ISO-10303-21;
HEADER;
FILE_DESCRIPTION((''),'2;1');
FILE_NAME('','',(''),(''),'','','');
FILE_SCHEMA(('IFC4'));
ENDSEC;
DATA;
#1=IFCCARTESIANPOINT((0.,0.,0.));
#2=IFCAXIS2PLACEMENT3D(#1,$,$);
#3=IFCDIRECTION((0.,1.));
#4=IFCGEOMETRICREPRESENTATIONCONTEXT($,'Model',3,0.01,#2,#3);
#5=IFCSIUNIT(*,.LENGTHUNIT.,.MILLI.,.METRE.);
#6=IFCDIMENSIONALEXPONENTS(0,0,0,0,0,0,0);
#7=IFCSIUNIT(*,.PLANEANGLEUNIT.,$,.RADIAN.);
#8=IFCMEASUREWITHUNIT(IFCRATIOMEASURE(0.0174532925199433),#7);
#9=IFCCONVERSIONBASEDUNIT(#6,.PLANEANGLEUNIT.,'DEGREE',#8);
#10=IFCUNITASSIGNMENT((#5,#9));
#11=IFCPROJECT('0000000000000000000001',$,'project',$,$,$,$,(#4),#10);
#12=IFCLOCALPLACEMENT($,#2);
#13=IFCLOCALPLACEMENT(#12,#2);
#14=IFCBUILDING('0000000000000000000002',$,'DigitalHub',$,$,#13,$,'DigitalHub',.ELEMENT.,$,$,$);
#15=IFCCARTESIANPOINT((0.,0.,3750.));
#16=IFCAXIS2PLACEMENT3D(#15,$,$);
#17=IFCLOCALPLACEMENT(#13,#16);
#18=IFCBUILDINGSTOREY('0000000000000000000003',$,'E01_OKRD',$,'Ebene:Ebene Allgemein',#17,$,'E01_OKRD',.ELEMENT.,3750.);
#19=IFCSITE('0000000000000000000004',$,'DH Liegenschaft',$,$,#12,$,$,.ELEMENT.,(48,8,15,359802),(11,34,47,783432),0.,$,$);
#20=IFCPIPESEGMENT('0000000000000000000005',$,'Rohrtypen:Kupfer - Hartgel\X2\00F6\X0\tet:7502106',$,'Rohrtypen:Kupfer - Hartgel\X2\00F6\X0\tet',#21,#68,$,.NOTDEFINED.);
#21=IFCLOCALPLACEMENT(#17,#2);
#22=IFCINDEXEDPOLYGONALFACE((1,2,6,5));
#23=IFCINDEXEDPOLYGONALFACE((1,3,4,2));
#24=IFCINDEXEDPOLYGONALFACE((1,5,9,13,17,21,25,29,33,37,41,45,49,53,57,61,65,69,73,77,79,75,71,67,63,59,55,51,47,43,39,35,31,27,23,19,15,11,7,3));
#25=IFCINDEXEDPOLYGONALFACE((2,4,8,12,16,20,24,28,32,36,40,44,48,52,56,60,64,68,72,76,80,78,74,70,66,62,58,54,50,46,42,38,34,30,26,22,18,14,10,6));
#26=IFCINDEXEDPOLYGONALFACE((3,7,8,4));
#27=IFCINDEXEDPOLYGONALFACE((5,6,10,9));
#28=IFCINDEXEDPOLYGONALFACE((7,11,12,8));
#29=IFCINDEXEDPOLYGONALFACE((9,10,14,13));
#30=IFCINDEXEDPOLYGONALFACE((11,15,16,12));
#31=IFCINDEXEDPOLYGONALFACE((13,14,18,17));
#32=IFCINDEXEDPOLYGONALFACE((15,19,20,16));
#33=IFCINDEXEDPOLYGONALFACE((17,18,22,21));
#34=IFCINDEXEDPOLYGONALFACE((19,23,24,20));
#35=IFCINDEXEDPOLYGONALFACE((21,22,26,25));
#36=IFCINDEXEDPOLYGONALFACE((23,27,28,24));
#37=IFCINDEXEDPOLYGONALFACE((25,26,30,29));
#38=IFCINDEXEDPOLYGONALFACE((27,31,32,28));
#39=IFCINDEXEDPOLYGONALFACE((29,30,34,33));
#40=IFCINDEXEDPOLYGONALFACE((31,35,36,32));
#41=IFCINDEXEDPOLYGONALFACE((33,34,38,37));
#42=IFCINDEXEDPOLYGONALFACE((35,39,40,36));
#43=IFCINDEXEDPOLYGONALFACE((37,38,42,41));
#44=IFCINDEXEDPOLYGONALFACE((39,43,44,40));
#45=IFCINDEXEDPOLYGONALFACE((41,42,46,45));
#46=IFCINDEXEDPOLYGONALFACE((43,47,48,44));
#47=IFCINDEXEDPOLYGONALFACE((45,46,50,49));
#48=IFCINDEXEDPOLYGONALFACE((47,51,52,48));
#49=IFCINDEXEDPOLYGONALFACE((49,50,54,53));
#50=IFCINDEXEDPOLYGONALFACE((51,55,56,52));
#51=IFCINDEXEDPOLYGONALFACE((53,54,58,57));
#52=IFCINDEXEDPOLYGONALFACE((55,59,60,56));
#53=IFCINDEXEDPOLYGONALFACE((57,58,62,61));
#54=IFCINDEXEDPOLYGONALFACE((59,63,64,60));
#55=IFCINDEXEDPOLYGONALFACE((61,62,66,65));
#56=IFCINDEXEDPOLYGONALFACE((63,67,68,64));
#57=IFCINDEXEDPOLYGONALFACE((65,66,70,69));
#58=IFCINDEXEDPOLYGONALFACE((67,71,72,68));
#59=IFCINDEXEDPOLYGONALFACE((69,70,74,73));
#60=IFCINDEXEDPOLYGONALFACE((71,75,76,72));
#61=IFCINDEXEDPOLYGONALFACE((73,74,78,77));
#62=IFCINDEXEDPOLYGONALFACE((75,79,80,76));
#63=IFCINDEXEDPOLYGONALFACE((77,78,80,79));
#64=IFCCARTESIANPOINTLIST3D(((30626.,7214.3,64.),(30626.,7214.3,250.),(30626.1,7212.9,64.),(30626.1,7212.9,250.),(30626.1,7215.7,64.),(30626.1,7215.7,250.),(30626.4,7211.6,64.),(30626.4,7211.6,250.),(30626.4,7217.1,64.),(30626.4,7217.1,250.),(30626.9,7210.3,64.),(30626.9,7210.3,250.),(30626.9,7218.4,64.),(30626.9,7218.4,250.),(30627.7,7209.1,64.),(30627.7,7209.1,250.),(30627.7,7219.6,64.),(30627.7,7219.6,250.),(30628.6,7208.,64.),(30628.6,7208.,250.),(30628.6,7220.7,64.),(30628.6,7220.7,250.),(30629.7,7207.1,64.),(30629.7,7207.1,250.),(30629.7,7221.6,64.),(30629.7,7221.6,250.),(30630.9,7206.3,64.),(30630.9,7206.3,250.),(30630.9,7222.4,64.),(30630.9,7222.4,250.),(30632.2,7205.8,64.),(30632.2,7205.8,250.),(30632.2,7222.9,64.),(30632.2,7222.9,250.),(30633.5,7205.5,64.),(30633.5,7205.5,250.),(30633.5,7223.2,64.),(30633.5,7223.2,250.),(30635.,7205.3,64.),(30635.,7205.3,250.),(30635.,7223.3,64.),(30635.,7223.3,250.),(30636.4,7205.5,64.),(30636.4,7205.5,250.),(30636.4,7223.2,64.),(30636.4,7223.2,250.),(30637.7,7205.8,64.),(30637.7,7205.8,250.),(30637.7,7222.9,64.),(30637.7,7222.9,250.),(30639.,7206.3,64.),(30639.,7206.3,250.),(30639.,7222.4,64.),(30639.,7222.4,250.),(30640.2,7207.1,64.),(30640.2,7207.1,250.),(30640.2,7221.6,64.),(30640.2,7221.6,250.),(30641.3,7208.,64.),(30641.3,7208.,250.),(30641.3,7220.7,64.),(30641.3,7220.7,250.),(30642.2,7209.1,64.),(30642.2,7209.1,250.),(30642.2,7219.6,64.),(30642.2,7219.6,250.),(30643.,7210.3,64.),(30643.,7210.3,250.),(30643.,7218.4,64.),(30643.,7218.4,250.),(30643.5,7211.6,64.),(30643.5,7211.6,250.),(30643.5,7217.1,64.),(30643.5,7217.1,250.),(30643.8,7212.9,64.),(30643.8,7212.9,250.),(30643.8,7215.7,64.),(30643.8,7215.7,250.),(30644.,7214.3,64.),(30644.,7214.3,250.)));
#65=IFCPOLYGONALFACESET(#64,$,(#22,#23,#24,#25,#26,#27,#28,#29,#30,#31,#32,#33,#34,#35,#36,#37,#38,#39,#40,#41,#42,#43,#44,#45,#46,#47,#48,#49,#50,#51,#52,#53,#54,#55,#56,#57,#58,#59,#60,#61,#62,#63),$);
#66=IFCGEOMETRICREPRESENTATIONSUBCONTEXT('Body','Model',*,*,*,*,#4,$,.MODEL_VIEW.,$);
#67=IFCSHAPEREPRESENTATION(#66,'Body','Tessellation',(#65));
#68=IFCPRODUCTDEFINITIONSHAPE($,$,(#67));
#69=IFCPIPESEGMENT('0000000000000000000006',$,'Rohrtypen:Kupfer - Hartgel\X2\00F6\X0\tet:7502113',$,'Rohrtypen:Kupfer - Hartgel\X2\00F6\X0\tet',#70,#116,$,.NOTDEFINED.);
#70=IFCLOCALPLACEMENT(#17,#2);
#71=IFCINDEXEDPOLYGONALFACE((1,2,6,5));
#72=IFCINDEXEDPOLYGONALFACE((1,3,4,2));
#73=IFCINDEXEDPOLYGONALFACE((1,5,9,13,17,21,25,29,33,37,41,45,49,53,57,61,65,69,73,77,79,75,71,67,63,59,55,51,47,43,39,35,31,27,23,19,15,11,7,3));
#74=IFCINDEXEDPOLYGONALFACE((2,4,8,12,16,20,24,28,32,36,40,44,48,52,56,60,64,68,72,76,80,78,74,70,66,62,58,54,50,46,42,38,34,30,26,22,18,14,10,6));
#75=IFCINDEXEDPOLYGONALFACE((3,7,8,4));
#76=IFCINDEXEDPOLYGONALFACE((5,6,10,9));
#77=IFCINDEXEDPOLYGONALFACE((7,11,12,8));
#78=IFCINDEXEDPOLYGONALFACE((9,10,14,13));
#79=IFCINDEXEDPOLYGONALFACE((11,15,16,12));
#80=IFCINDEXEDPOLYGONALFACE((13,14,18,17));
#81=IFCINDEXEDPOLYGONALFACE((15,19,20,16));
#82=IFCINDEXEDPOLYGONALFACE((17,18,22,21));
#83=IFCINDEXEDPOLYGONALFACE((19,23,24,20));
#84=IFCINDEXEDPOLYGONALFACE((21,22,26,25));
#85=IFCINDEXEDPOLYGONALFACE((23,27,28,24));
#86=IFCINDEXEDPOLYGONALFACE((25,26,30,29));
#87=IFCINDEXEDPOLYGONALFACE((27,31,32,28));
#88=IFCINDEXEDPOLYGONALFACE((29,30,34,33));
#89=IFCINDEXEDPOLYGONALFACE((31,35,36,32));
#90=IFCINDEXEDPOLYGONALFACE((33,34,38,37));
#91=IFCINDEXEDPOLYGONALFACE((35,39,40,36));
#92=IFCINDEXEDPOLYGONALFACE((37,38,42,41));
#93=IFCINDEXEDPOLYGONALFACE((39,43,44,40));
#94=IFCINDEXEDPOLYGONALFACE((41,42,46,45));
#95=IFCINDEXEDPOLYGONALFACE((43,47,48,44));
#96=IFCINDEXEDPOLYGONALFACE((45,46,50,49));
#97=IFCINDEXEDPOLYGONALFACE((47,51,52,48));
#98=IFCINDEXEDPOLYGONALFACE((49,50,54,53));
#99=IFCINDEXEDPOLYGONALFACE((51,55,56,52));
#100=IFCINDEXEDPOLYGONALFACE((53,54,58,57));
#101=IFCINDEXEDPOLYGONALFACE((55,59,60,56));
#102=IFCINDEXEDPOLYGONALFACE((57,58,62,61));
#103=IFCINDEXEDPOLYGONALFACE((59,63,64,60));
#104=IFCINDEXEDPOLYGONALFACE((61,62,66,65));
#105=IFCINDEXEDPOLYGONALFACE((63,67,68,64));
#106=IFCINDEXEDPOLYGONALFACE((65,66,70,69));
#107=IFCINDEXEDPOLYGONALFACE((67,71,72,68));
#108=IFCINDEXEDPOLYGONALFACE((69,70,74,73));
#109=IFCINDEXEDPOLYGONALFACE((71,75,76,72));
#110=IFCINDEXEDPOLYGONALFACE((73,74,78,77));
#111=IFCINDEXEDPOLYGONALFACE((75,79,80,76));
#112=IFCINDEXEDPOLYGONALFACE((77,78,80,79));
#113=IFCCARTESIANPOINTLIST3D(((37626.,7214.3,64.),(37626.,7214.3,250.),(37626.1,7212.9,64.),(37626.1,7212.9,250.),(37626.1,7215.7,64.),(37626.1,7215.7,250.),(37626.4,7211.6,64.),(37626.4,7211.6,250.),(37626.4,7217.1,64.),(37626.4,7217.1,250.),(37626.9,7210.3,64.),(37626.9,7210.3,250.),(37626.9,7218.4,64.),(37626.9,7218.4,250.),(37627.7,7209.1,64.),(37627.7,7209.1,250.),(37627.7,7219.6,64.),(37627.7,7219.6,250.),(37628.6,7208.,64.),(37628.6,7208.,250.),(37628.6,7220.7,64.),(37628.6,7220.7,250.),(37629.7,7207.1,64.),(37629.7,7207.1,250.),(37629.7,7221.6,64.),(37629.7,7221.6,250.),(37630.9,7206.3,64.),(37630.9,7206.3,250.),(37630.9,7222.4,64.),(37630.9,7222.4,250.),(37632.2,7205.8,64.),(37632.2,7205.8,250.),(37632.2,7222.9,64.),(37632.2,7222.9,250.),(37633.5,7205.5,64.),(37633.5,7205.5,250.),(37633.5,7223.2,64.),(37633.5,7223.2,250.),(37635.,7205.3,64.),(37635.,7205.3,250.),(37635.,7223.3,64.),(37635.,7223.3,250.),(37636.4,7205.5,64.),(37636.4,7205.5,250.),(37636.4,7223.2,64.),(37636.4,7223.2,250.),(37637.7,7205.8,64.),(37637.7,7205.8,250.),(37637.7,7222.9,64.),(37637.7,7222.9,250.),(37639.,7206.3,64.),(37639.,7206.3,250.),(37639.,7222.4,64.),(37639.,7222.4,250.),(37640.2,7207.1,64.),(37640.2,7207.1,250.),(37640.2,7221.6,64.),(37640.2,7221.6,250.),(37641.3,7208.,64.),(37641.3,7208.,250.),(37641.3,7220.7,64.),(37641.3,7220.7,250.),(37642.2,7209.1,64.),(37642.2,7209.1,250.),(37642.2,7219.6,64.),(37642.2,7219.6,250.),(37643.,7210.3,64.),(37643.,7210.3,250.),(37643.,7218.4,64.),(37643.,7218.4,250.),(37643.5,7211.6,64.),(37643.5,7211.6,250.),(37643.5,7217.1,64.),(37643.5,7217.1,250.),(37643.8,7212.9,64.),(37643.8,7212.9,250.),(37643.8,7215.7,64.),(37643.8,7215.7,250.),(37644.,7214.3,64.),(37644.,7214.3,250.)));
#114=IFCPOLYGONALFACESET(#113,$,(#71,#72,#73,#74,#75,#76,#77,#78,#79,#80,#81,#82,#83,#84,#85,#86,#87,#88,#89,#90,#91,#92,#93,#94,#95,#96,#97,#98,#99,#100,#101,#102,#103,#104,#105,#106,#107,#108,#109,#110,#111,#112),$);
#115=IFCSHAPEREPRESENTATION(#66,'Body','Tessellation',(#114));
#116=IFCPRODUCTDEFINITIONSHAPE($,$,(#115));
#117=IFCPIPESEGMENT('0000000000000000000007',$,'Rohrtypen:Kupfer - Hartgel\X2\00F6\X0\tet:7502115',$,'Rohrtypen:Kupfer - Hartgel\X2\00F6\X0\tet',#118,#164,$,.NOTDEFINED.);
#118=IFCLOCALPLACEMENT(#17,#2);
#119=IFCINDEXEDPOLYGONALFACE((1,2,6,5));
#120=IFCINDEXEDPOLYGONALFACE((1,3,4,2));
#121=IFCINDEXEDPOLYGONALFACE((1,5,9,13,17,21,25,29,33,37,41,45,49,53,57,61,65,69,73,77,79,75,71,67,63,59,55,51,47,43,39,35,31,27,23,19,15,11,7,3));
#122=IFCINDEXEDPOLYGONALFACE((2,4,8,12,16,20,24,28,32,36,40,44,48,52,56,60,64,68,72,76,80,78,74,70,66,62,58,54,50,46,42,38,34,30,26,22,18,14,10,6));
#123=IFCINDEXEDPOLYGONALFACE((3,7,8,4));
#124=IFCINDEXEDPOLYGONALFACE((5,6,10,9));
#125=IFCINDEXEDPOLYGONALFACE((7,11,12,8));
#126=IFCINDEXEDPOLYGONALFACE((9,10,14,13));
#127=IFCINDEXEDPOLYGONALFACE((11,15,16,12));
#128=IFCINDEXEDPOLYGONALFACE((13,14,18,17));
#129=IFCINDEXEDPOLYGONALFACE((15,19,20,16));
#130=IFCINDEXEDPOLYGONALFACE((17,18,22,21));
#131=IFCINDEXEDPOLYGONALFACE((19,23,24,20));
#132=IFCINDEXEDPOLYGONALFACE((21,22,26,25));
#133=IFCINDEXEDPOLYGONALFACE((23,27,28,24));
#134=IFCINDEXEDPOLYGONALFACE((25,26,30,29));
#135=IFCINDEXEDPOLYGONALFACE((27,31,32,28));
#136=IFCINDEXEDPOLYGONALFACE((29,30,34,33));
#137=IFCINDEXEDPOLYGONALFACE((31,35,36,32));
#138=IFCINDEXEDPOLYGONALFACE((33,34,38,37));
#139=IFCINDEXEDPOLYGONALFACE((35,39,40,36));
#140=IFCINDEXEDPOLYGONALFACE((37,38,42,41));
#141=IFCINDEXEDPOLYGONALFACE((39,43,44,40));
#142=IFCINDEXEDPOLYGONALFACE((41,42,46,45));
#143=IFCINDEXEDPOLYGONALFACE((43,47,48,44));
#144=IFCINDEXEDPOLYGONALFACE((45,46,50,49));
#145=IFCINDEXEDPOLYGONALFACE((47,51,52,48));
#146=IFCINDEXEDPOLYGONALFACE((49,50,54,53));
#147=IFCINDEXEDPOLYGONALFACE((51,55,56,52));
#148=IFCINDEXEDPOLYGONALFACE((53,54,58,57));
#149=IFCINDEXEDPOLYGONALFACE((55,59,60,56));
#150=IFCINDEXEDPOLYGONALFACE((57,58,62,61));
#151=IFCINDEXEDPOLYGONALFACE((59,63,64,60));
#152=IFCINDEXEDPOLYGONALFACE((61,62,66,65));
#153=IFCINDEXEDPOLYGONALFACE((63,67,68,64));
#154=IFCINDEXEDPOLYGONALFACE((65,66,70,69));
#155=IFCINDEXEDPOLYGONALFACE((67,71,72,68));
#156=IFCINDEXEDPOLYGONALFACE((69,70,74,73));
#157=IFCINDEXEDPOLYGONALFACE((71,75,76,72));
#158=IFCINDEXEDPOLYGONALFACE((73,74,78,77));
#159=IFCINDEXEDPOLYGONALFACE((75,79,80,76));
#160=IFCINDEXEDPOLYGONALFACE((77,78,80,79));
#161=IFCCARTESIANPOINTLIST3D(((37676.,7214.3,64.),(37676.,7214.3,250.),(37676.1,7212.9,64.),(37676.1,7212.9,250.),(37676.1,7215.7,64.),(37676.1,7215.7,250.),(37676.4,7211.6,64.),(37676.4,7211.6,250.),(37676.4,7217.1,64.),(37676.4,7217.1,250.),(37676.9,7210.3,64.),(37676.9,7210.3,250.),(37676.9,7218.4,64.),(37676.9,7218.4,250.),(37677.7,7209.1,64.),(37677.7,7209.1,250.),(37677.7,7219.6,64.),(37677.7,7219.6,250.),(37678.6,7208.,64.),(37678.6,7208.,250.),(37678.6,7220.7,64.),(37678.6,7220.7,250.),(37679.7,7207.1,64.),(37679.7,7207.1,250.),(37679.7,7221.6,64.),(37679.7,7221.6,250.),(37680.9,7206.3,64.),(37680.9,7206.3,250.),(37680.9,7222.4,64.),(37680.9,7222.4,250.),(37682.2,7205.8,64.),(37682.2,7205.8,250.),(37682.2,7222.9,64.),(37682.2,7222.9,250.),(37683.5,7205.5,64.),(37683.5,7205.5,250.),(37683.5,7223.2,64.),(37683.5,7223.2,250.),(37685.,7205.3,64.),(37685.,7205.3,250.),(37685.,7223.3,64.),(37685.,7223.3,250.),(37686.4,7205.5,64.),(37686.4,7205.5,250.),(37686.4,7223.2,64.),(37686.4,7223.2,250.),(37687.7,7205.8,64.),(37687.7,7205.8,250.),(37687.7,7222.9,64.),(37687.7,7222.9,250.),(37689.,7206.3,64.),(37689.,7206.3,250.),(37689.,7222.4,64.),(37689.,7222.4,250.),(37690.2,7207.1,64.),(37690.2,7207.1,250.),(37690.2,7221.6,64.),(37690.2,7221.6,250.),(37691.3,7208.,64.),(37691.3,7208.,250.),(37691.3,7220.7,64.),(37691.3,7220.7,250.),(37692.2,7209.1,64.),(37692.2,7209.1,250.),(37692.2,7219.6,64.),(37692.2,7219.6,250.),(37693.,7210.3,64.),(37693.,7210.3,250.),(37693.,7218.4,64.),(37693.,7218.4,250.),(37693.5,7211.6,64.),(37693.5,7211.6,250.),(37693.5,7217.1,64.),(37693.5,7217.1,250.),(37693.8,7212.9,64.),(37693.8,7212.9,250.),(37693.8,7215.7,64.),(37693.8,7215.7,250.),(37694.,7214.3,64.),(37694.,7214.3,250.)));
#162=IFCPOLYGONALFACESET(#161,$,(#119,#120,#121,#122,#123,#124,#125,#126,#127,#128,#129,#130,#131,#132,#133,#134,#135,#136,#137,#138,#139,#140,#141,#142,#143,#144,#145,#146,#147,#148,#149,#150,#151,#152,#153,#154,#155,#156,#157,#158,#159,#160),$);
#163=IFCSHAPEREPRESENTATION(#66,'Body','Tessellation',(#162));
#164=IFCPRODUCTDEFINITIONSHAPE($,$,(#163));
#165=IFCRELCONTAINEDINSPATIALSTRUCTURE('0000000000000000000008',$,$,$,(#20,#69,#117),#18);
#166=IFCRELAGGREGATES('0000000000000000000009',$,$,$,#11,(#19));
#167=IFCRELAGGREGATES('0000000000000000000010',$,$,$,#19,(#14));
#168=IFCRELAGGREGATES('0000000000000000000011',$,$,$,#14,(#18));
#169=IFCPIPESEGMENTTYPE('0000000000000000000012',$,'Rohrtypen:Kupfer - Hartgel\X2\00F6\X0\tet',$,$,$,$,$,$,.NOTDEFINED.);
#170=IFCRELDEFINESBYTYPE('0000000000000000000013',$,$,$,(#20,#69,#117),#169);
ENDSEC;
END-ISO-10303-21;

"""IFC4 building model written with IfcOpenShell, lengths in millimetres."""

from ifc_helpers import new_model, entity, si_unit, converted_unit, direction, frame, origin, place, context, subcontext, project, spatial, indexed_curve, outline, extrude, type_object, element, save


model = new_model("IFC4")

# Units and contexts
model_context = context("Model", 3, precision=0.01, world=origin(), true_north=direction((0.0, 1.0)))
body_context = subcontext(model_context, "Body", "Model", "MODEL_VIEW")
ifc_project = project(units=[si_unit("LENGTHUNIT", "METRE", prefix="MILLI"), converted_unit("PLANEANGLEUNIT", "DEGREE", entity("IfcRatioMeasure", 0.0174532925199433), si_unit("PLANEANGLEUNIT", "RADIAN"), dimensions=[0, 0, 0, 0, 0, 0, 0])], contexts=[model_context])

# Site, building, storey
site_placement = place(None, origin())
site = spatial("IfcSite", under=ifc_project, at=site_placement, Name="DH Liegenschaft", CompositionType="ELEMENT", RefLatitude=(48, 8, 15, 359802), RefLongitude=(11, 34, 47, 783432), RefElevation=0.0)
building_placement = place(site_placement, origin())
building = spatial("IfcBuilding", under=site, at=building_placement, Name="DigitalHub", LongName="DigitalHub", CompositionType="ELEMENT")
storey_placement = place(building_placement, frame((0.0, 0.0, 3750.0)))
storey = spatial("IfcBuildingStorey", under=building, at=storey_placement, Name="E01_OKRD", ObjectType="Ebene:Ebene Allgemein", LongName="E01_OKRD", CompositionType="ELEMENT", Elevation=3750.0)

# Pipe segments
pipe_segment_type = type_object("IfcPipeSegmentType", Name="Rohrtypen:Kupfer - Hartgelötet", PredefinedType="NOTDEFINED")
pipe_segment_1_placement = place(storey_placement, frame((30624.4, 7203.7, 64.0)))
element("IfcPipeSegment", 1, at=pipe_segment_1_placement, inside=storey, type_object=pipe_segment_type, Name="Rohrtypen:Kupfer - Hartgelötet:7502106", ObjectType="Rohrtypen:Kupfer - Hartgelötet", PredefinedType="NOTDEFINED", context=body_context, shape_type="SweptSolid", body=[
    extrude(outline(indexed_curve([(9.0, 0.0), (8.9, 1.4), (8.6, 2.8), (8.0, 4.1), (7.3, 5.3), (6.4, 6.4), (5.3, 7.3), (4.1, 8.0), (2.8, 8.6), (1.4, 8.9), (0.0, 9.0), (-1.4, 8.9), (-2.8, 8.6), (-4.1, 8.0), (-5.3, 7.3), (-6.4, 6.4), (-7.3, 5.3), (-8.0, 4.1), (-8.6, 2.8), (-8.9, 1.4), (-9.0, 0.0), (-8.9, -1.4), (-8.6, -2.8), (-8.0, -4.1), (-7.3, -5.3), (-6.4, -6.4), (-5.3, -7.3), (-4.1, -8.0), (-2.8, -8.6), (-1.4, -8.9), (0.0, -9.0), (1.4, -8.9), (2.8, -8.6), (4.1, -8.0), (5.3, -7.3), (6.4, -6.4), (7.3, -5.3), (8.0, -4.1), (8.6, -2.8), (8.9, -1.4), (9.0, 0.0)], self_intersect=False)), frame((10.6, 10.6, 0.0)), (0.0, 0.0, 1.0), 186.0),
])
pipe_segment_2_placement = place(storey_placement, frame((37624.4, 7203.7, 64.0)))
element("IfcPipeSegment", 2, at=pipe_segment_2_placement, inside=storey, type_object=pipe_segment_type, Name="Rohrtypen:Kupfer - Hartgelötet:7502113", ObjectType="Rohrtypen:Kupfer - Hartgelötet", PredefinedType="NOTDEFINED", context=body_context, shape_type="SweptSolid", body=[
    extrude(outline(indexed_curve([(9.0, 0.0), (8.9, 1.4), (8.6, 2.8), (8.0, 4.1), (7.3, 5.3), (6.4, 6.4), (5.3, 7.3), (4.1, 8.0), (2.8, 8.6), (1.4, 8.9), (0.0, 9.0), (-1.4, 8.9), (-2.8, 8.6), (-4.1, 8.0), (-5.3, 7.3), (-6.4, 6.4), (-7.3, 5.3), (-8.0, 4.1), (-8.6, 2.8), (-8.9, 1.4), (-9.0, 0.0), (-8.9, -1.4), (-8.6, -2.8), (-8.0, -4.1), (-7.3, -5.3), (-6.4, -6.4), (-5.3, -7.3), (-4.1, -8.0), (-2.8, -8.6), (-1.4, -8.9), (0.0, -9.0), (1.4, -8.9), (2.8, -8.6), (4.1, -8.0), (5.3, -7.3), (6.4, -6.4), (7.3, -5.3), (8.0, -4.1), (8.6, -2.8), (8.9, -1.4), (9.0, 0.0)], self_intersect=False)), frame((10.6, 10.6, 0.0)), (0.0, 0.0, 1.0), 186.0),
])
pipe_segment_3_placement = place(storey_placement, frame((37674.4, 7203.7, 64.0)))
element("IfcPipeSegment", 3, at=pipe_segment_3_placement, inside=storey, type_object=pipe_segment_type, Name="Rohrtypen:Kupfer - Hartgelötet:7502115", ObjectType="Rohrtypen:Kupfer - Hartgelötet", PredefinedType="NOTDEFINED", context=body_context, shape_type="SweptSolid", body=[
    extrude(outline(indexed_curve([(9.0, 0.0), (8.9, 1.4), (8.6, 2.8), (8.0, 4.1), (7.3, 5.3), (6.4, 6.4), (5.3, 7.3), (4.1, 8.0), (2.8, 8.6), (1.4, 8.9), (0.0, 9.0), (-1.4, 8.9), (-2.8, 8.6), (-4.1, 8.0), (-5.3, 7.3), (-6.4, 6.4), (-7.3, 5.3), (-8.0, 4.1), (-8.6, 2.8), (-8.9, 1.4), (-9.0, 0.0), (-8.9, -1.4), (-8.6, -2.8), (-8.0, -4.1), (-7.3, -5.3), (-6.4, -6.4), (-5.3, -7.3), (-4.1, -8.0), (-2.8, -8.6), (-1.4, -8.9), (0.0, -9.0), (1.4, -8.9), (2.8, -8.6), (4.1, -8.0), (5.3, -7.3), (6.4, -6.4), (7.3, -5.3), (8.0, -4.1), (8.6, -2.8), (8.9, -1.4), (9.0, 0.0)], self_intersect=False)), frame((10.6, 10.6, 0.0)), (0.0, 0.0, 1.0), 186.0),
])

save(model, "model.ifc")
